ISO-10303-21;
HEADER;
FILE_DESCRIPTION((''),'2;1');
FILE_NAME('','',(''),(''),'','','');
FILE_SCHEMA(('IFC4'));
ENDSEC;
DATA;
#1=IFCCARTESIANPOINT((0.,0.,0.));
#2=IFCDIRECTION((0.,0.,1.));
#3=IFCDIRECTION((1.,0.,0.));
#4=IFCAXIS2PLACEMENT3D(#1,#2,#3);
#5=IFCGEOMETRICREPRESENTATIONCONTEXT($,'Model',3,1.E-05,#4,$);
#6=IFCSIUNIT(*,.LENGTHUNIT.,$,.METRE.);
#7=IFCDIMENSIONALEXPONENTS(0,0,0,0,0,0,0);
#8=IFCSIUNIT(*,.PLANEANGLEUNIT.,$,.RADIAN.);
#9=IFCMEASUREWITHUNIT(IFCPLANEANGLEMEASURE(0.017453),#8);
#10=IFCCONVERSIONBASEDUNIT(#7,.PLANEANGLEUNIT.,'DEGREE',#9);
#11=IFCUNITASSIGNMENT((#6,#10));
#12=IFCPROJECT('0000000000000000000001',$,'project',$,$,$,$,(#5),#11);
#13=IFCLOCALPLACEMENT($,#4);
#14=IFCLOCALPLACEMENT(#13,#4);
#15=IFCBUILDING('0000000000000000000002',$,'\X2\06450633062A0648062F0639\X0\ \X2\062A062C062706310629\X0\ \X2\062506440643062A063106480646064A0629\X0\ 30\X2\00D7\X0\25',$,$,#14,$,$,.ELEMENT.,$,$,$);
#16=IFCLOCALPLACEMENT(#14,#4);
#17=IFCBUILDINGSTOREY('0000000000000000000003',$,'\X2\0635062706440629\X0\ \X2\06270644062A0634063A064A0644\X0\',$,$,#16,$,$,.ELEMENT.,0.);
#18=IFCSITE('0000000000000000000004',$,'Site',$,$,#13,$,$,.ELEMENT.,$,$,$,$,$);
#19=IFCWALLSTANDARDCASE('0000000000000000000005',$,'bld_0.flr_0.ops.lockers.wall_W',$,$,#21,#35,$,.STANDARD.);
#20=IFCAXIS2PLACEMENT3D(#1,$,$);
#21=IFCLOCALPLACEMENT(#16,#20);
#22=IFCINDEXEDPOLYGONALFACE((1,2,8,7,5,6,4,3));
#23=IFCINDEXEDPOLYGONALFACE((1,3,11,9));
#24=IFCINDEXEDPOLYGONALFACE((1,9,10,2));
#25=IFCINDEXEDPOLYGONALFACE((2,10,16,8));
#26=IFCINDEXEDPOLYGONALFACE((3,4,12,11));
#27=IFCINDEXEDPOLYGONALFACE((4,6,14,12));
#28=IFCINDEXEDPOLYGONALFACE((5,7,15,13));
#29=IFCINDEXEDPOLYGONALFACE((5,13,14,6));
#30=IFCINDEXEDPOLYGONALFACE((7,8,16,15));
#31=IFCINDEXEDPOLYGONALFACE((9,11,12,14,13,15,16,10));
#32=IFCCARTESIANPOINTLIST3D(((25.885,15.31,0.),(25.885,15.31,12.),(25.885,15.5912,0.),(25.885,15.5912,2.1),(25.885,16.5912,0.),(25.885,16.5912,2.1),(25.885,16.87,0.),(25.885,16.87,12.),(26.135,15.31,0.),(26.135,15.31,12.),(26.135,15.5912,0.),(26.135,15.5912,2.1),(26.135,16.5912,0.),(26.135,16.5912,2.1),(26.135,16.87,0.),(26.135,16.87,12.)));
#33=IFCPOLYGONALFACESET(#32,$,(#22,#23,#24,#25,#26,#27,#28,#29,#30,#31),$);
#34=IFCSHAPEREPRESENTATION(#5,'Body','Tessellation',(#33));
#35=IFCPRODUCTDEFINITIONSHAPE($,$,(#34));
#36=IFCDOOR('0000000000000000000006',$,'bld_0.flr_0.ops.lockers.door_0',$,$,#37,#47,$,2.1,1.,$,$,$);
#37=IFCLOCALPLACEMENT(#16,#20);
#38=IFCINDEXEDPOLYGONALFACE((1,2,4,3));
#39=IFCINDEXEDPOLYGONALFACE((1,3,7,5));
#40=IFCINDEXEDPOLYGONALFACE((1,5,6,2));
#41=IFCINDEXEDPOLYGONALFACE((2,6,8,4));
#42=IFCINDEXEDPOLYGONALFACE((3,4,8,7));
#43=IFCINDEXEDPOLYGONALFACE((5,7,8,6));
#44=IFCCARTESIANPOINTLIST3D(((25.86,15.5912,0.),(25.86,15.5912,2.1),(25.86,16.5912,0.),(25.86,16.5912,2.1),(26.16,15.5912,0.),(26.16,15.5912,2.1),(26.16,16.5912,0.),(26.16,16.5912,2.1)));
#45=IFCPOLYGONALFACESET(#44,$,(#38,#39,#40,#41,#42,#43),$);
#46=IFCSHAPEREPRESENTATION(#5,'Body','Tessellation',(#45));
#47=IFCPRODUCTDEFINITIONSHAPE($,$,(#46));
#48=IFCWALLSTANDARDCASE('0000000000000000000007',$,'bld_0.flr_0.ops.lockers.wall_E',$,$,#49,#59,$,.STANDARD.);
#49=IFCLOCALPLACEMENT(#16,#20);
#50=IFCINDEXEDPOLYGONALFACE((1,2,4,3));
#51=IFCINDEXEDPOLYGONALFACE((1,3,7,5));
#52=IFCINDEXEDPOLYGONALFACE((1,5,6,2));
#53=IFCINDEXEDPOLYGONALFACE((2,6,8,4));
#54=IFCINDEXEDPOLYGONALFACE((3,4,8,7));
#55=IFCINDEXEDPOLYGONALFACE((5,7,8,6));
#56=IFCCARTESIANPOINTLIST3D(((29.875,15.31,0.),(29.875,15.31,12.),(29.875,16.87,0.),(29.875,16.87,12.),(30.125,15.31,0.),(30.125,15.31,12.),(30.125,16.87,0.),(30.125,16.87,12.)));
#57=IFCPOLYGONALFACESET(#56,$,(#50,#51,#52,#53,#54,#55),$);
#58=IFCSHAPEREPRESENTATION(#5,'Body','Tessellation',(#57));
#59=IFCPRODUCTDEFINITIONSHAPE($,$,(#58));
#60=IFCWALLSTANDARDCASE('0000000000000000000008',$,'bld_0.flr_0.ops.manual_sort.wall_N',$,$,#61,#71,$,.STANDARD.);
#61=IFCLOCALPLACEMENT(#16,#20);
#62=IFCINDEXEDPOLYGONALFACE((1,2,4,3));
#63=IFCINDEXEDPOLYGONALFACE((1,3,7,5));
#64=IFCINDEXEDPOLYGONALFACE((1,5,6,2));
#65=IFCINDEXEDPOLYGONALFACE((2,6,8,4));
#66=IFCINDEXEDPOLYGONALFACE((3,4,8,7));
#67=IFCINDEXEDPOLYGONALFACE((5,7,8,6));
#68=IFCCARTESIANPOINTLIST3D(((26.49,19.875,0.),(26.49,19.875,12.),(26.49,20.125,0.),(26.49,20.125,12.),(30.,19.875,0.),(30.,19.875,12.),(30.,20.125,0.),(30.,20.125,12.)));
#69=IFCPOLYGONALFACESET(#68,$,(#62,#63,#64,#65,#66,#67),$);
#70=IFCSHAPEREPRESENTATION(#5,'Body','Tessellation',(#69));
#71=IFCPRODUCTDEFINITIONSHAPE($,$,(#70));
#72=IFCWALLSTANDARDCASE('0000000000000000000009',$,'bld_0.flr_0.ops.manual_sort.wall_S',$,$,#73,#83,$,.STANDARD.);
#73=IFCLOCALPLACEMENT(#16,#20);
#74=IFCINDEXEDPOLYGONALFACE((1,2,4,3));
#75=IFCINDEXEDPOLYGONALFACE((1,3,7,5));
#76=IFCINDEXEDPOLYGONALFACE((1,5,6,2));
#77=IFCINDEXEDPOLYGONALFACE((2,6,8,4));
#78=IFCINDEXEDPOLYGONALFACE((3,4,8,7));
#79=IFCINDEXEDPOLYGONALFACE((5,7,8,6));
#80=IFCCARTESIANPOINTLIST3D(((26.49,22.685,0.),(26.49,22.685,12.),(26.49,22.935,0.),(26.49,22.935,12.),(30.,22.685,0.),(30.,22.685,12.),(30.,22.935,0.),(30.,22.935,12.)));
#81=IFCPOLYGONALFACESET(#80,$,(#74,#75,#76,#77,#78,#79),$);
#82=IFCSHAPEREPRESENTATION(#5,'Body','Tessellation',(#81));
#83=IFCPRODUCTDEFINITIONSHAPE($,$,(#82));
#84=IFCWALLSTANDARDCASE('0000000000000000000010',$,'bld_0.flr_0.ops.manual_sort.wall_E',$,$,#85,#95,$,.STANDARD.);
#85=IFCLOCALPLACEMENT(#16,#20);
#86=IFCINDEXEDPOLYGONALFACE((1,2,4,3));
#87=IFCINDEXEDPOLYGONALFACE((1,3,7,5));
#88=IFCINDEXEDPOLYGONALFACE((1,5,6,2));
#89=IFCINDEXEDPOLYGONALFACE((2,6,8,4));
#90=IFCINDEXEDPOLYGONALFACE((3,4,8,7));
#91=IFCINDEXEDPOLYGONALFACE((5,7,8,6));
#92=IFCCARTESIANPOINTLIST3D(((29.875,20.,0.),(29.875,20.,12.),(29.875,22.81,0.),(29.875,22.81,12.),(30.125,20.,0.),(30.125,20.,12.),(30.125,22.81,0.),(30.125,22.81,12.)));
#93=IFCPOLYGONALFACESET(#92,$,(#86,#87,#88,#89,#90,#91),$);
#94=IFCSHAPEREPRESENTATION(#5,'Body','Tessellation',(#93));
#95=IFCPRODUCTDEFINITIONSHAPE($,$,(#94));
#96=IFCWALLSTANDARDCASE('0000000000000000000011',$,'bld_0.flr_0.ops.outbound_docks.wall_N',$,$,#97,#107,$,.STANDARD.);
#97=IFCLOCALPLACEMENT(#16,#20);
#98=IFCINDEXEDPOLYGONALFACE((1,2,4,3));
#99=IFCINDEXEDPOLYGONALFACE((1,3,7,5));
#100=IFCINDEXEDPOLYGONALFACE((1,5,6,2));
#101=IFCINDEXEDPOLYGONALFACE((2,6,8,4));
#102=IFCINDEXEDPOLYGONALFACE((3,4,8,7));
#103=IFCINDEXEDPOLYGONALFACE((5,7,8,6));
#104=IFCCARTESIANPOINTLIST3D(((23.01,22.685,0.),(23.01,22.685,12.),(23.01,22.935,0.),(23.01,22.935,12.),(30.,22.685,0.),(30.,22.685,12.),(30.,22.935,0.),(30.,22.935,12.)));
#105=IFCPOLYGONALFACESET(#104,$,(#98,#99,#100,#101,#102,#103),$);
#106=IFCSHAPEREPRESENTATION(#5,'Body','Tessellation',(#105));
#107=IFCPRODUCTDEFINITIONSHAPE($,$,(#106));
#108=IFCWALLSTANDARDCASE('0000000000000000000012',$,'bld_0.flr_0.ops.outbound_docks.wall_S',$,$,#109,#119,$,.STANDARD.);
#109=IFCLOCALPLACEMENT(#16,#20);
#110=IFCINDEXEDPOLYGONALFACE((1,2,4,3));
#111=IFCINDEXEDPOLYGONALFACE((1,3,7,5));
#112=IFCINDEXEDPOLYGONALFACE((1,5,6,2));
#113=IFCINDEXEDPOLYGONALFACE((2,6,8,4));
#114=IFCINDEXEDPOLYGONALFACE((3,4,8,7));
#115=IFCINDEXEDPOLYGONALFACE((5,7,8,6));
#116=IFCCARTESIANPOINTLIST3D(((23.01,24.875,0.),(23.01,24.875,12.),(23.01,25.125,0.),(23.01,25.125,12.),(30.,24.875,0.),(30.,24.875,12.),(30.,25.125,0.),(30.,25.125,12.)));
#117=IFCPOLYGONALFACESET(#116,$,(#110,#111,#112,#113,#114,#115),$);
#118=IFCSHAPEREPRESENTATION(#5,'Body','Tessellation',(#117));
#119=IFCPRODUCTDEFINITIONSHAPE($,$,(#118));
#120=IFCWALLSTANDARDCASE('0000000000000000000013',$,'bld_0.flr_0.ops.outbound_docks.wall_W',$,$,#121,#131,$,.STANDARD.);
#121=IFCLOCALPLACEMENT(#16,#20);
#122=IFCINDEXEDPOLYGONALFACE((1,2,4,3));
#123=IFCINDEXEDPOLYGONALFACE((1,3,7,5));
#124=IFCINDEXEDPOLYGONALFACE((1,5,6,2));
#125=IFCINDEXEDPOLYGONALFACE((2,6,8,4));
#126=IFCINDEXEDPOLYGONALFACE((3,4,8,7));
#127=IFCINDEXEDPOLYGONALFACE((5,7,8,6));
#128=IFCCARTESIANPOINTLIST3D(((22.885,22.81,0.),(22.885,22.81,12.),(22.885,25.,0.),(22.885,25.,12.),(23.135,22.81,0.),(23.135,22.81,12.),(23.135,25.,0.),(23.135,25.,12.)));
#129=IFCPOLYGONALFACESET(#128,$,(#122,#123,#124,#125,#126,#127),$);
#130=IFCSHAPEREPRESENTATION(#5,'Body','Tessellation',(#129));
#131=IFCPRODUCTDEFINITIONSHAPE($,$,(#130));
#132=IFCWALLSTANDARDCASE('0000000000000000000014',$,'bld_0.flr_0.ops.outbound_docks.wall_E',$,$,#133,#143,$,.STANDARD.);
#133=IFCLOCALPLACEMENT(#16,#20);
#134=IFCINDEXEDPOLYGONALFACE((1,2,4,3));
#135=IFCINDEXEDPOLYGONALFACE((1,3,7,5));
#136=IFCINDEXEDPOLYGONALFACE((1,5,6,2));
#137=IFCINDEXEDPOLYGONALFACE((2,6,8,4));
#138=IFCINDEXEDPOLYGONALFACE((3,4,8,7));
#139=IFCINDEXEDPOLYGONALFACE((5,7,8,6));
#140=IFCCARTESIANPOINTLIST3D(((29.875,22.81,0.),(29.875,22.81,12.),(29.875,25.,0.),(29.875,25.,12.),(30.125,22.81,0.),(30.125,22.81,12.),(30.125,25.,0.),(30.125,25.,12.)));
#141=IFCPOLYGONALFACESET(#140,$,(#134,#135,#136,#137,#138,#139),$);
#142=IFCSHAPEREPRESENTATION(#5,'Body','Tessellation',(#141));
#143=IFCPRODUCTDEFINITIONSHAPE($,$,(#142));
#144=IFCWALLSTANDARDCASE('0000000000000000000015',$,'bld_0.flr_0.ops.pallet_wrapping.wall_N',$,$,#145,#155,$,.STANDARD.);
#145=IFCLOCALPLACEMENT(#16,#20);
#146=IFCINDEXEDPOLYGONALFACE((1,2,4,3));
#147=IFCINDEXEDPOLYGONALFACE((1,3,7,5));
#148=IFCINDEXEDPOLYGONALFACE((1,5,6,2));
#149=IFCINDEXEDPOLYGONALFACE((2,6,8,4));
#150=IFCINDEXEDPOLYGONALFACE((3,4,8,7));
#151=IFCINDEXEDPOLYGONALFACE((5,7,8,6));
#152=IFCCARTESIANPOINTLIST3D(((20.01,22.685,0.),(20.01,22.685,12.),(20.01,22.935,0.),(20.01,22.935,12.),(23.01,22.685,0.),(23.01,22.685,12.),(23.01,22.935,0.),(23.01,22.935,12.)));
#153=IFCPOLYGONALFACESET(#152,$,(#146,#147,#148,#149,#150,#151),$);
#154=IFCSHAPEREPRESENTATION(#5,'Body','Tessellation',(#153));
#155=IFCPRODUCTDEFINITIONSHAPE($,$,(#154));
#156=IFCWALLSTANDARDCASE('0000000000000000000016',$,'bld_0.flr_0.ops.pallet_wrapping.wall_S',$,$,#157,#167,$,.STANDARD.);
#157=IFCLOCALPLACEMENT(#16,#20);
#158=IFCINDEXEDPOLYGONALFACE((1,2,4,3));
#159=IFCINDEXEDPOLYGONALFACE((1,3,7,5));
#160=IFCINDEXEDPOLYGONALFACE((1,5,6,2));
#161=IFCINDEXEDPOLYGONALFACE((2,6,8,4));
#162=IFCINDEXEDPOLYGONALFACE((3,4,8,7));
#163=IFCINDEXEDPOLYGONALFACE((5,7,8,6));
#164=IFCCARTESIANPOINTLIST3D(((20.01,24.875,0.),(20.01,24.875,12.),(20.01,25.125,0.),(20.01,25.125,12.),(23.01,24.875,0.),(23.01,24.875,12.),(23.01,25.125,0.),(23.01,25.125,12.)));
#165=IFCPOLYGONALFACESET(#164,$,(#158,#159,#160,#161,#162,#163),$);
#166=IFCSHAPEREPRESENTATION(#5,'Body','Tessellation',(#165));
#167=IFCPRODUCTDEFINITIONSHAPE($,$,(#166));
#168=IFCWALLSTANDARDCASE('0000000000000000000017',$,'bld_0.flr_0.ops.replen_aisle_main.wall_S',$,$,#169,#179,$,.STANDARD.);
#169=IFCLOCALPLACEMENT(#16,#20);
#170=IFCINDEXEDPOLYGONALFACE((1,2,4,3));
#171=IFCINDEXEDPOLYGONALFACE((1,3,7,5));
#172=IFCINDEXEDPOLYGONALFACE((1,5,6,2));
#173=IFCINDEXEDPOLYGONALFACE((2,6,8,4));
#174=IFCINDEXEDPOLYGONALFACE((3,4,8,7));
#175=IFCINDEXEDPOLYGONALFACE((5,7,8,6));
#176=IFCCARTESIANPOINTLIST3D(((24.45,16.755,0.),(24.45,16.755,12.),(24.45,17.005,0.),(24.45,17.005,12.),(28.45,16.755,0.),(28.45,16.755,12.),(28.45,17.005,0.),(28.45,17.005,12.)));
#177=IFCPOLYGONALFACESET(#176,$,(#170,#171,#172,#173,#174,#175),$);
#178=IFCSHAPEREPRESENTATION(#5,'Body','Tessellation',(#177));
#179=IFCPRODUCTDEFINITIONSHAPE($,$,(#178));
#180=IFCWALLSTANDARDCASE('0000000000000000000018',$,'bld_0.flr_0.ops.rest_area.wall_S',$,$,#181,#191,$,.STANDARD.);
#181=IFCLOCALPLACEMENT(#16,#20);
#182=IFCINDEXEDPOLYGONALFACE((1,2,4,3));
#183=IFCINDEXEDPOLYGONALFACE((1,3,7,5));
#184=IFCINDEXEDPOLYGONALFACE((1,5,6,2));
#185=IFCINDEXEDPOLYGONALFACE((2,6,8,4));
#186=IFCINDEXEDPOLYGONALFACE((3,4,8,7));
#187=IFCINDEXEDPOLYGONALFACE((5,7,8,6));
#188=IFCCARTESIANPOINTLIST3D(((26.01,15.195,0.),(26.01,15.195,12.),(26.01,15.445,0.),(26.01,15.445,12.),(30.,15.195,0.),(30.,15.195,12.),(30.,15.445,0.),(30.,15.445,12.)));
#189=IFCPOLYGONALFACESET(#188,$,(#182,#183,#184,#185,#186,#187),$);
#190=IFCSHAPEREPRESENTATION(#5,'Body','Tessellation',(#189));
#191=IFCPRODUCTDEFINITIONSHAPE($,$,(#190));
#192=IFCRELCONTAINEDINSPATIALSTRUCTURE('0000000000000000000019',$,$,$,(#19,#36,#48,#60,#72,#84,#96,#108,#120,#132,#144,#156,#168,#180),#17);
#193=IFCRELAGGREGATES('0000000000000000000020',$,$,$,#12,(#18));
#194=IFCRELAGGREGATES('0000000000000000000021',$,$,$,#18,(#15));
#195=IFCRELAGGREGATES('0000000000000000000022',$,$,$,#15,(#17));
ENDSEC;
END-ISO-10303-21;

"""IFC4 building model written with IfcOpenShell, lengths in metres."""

from ifc_helpers import new_model, entity, si_unit, converted_unit, frame, frame_2d, origin_with_axes, origin_2d_with_axis, place, context, project, spatial, rectangle, extrude, element, fill, save


model = new_model("IFC4")

# Units and contexts
model_context = context("Model", 3, precision=1e-05, world=origin_with_axes())
ifc_project = project(units=[si_unit("LENGTHUNIT", "METRE"), converted_unit("PLANEANGLEUNIT", "DEGREE", entity("IfcPlaneAngleMeasure", 0.017453), si_unit("PLANEANGLEUNIT", "RADIAN"), dimensions=[0, 0, 0, 0, 0, 0, 0])], contexts=[model_context])

# Site, building, storey
site_placement = place(None, origin_with_axes())
site = spatial("IfcSite", under=ifc_project, at=site_placement, Name="Site", CompositionType="ELEMENT")
building_placement = place(site_placement, origin_with_axes())
building = spatial("IfcBuilding", under=site, at=building_placement, Name="مستودع تجارة إلكترونية 30×25", CompositionType="ELEMENT")
storey_placement = place(building_placement, origin_with_axes())
storey = spatial("IfcBuildingStorey", under=building, at=storey_placement, Name="صالة التشغيل", CompositionType="ELEMENT", Elevation=0.0)

# Wall, opening, door
wall_1_placement = place(storey_placement, frame((26.01, 15.31, 0.0), z_axis=(0.0, 0.0, 1.0), x_axis=(0.0, 1.0, 0.0)))
wall_1 = element("IfcWallStandardCase", 1, at=wall_1_placement, inside=storey, Name="bld_0.flr_0.ops.lockers.wall_W", PredefinedType="STANDARD", context=model_context, shape_type="SweptSolid", body=[
    extrude(rectangle(XDim=1.56, YDim=0.25, at=frame_2d((0.78, 0.0), x_axis=(1.0, 0.0))), origin_with_axes(), (0.0, 0.0, 1.0), 12.0),
])
opening_1_placement = place(storey_placement, frame((26.01, 16.0912, 0.0), z_axis=(0.0, 0.0, 1.0), x_axis=(0.0, 1.0, 0.0)))
opening_1 = element("IfcOpeningElement", 2, at=opening_1_placement, cuts=wall_1, PredefinedType="OPENING", context=model_context, shape_type="SweptSolid", body=[
    extrude(rectangle(XDim=1.0, YDim=0.3, at=origin_2d_with_axis()), origin_with_axes(), (0.0, 0.0, 1.0), 2.1),
])
door_1_placement = place(storey_placement, frame((26.01, 16.0912, 0.0), z_axis=(0.0, 0.0, 1.0), x_axis=(0.0, 1.0, 0.0)))
door_1 = element("IfcDoor", 3, at=door_1_placement, inside=storey, Name="bld_0.flr_0.ops.lockers.door_0", OverallHeight=2.1, OverallWidth=1.0, context=model_context, shape_type="SweptSolid", body=[
    extrude(rectangle(XDim=1.0, YDim=0.3, at=origin_2d_with_axis()), origin_with_axes(), (0.0, 0.0, 1.0), 2.1),
])
fill(opening_1, door_1)

# Walls
wall_2_placement = place(storey_placement, frame((30.0, 15.31, 0.0), z_axis=(0.0, 0.0, 1.0), x_axis=(0.0, 1.0, 0.0)))
element("IfcWallStandardCase", 4, at=wall_2_placement, inside=storey, Name="bld_0.flr_0.ops.lockers.wall_E", PredefinedType="STANDARD", context=model_context, shape_type="SweptSolid", body=[
    extrude(rectangle(XDim=1.56, YDim=0.25, at=frame_2d((0.78, 0.0), x_axis=(1.0, 0.0))), origin_with_axes(), (0.0, 0.0, 1.0), 12.0),
])
for number, where, z_axis, x_axis, name in (
    (5, (26.49, 20.0, 0.0), (0.0, 0.0, 1.0), (1.0, 0.0, 0.0), "bld_0.flr_0.ops.manual_sort.wall_N"),
    (6, (26.49, 22.81, 0.0), (0.0, 0.0, 1.0), (1.0, 0.0, 0.0), "bld_0.flr_0.ops.manual_sort.wall_S"),
):
    element("IfcWallStandardCase", number, at=place(storey_placement, frame(where, z_axis=z_axis, x_axis=x_axis)), inside=storey, Name=name, PredefinedType="STANDARD", context=model_context, shape_type="SweptSolid", body=[
        extrude(rectangle(XDim=3.51, YDim=0.25, at=frame_2d((1.755, 0.0), x_axis=(1.0, 0.0))), origin_with_axes(), (0.0, 0.0, 1.0), 12.0),
    ])
for number, where, z_axis, x_axis, name in (
    (7, (30.0, 20.0, 0.0), (0.0, 0.0, 1.0), (0.0, 1.0, 0.0), "bld_0.flr_0.ops.manual_sort.wall_E"),
):
    element("IfcWallStandardCase", number, at=place(storey_placement, frame(where, z_axis=z_axis, x_axis=x_axis)), inside=storey, Name=name, PredefinedType="STANDARD", context=model_context, shape_type="SweptSolid", body=[
        extrude(rectangle(XDim=2.81, YDim=0.25, at=frame_2d((1.405, 0.0), x_axis=(1.0, 0.0))), origin_with_axes(), (0.0, 0.0, 1.0), 12.0),
    ])
for number, where, z_axis, x_axis, name in (
    (8, (23.01, 22.81, 0.0), (0.0, 0.0, 1.0), (1.0, 0.0, 0.0), "bld_0.flr_0.ops.outbound_docks.wall_N"),
    (9, (23.01, 25.0, 0.0), (0.0, 0.0, 1.0), (1.0, 0.0, 0.0), "bld_0.flr_0.ops.outbound_docks.wall_S"),
):
    element("IfcWallStandardCase", number, at=place(storey_placement, frame(where, z_axis=z_axis, x_axis=x_axis)), inside=storey, Name=name, PredefinedType="STANDARD", context=model_context, shape_type="SweptSolid", body=[
        extrude(rectangle(XDim=6.99, YDim=0.25, at=frame_2d((3.495, 0.0), x_axis=(1.0, 0.0))), origin_with_axes(), (0.0, 0.0, 1.0), 12.0),
    ])
for number, where, z_axis, x_axis, name in (
    (10, (23.01, 22.81, 0.0), (0.0, 0.0, 1.0), (0.0, 1.0, 0.0), "bld_0.flr_0.ops.outbound_docks.wall_W"),
    (11, (30.0, 22.81, 0.0), (0.0, 0.0, 1.0), (0.0, 1.0, 0.0), "bld_0.flr_0.ops.outbound_docks.wall_E"),
):
    element("IfcWallStandardCase", number, at=place(storey_placement, frame(where, z_axis=z_axis, x_axis=x_axis)), inside=storey, Name=name, PredefinedType="STANDARD", context=model_context, shape_type="SweptSolid", body=[
        extrude(rectangle(XDim=2.19, YDim=0.25, at=frame_2d((1.095, 0.0), x_axis=(1.0, 0.0))), origin_with_axes(), (0.0, 0.0, 1.0), 12.0),
    ])
for number, where, z_axis, x_axis, name in (
    (12, (20.01, 22.81, 0.0), (0.0, 0.0, 1.0), (1.0, 0.0, 0.0), "bld_0.flr_0.ops.pallet_wrapping.wall_N"),
    (13, (20.01, 25.0, 0.0), (0.0, 0.0, 1.0), (1.0, 0.0, 0.0), "bld_0.flr_0.ops.pallet_wrapping.wall_S"),
):
    element("IfcWallStandardCase", number, at=place(storey_placement, frame(where, z_axis=z_axis, x_axis=x_axis)), inside=storey, Name=name, PredefinedType="STANDARD", context=model_context, shape_type="SweptSolid", body=[
        extrude(rectangle(XDim=3.0, YDim=0.25, at=frame_2d((1.5, 0.0), x_axis=(1.0, 0.0))), origin_with_axes(), (0.0, 0.0, 1.0), 12.0),
    ])
wall_3_placement = place(storey_placement, frame((24.45, 16.88, 0.0), z_axis=(0.0, 0.0, 1.0), x_axis=(1.0, 0.0, 0.0)))
element("IfcWallStandardCase", 14, at=wall_3_placement, inside=storey, Name="bld_0.flr_0.ops.replen_aisle_main.wall_S", PredefinedType="STANDARD", context=model_context, shape_type="SweptSolid", body=[
    extrude(rectangle(XDim=4.0, YDim=0.25, at=frame_2d((2.0, 0.0), x_axis=(1.0, 0.0))), origin_with_axes(), (0.0, 0.0, 1.0), 12.0),
])
wall_4_placement = place(storey_placement, frame((26.01, 15.32, 0.0), z_axis=(0.0, 0.0, 1.0), x_axis=(1.0, 0.0, 0.0)))
element("IfcWallStandardCase", 15, at=wall_4_placement, inside=storey, Name="bld_0.flr_0.ops.rest_area.wall_S", PredefinedType="STANDARD", context=model_context, shape_type="SweptSolid", body=[
    extrude(rectangle(XDim=3.99, YDim=0.25, at=frame_2d((1.995, 0.0), x_axis=(1.0, 0.0))), origin_with_axes(), (0.0, 0.0, 1.0), 12.0),
])

save(model, "model.ifc")
